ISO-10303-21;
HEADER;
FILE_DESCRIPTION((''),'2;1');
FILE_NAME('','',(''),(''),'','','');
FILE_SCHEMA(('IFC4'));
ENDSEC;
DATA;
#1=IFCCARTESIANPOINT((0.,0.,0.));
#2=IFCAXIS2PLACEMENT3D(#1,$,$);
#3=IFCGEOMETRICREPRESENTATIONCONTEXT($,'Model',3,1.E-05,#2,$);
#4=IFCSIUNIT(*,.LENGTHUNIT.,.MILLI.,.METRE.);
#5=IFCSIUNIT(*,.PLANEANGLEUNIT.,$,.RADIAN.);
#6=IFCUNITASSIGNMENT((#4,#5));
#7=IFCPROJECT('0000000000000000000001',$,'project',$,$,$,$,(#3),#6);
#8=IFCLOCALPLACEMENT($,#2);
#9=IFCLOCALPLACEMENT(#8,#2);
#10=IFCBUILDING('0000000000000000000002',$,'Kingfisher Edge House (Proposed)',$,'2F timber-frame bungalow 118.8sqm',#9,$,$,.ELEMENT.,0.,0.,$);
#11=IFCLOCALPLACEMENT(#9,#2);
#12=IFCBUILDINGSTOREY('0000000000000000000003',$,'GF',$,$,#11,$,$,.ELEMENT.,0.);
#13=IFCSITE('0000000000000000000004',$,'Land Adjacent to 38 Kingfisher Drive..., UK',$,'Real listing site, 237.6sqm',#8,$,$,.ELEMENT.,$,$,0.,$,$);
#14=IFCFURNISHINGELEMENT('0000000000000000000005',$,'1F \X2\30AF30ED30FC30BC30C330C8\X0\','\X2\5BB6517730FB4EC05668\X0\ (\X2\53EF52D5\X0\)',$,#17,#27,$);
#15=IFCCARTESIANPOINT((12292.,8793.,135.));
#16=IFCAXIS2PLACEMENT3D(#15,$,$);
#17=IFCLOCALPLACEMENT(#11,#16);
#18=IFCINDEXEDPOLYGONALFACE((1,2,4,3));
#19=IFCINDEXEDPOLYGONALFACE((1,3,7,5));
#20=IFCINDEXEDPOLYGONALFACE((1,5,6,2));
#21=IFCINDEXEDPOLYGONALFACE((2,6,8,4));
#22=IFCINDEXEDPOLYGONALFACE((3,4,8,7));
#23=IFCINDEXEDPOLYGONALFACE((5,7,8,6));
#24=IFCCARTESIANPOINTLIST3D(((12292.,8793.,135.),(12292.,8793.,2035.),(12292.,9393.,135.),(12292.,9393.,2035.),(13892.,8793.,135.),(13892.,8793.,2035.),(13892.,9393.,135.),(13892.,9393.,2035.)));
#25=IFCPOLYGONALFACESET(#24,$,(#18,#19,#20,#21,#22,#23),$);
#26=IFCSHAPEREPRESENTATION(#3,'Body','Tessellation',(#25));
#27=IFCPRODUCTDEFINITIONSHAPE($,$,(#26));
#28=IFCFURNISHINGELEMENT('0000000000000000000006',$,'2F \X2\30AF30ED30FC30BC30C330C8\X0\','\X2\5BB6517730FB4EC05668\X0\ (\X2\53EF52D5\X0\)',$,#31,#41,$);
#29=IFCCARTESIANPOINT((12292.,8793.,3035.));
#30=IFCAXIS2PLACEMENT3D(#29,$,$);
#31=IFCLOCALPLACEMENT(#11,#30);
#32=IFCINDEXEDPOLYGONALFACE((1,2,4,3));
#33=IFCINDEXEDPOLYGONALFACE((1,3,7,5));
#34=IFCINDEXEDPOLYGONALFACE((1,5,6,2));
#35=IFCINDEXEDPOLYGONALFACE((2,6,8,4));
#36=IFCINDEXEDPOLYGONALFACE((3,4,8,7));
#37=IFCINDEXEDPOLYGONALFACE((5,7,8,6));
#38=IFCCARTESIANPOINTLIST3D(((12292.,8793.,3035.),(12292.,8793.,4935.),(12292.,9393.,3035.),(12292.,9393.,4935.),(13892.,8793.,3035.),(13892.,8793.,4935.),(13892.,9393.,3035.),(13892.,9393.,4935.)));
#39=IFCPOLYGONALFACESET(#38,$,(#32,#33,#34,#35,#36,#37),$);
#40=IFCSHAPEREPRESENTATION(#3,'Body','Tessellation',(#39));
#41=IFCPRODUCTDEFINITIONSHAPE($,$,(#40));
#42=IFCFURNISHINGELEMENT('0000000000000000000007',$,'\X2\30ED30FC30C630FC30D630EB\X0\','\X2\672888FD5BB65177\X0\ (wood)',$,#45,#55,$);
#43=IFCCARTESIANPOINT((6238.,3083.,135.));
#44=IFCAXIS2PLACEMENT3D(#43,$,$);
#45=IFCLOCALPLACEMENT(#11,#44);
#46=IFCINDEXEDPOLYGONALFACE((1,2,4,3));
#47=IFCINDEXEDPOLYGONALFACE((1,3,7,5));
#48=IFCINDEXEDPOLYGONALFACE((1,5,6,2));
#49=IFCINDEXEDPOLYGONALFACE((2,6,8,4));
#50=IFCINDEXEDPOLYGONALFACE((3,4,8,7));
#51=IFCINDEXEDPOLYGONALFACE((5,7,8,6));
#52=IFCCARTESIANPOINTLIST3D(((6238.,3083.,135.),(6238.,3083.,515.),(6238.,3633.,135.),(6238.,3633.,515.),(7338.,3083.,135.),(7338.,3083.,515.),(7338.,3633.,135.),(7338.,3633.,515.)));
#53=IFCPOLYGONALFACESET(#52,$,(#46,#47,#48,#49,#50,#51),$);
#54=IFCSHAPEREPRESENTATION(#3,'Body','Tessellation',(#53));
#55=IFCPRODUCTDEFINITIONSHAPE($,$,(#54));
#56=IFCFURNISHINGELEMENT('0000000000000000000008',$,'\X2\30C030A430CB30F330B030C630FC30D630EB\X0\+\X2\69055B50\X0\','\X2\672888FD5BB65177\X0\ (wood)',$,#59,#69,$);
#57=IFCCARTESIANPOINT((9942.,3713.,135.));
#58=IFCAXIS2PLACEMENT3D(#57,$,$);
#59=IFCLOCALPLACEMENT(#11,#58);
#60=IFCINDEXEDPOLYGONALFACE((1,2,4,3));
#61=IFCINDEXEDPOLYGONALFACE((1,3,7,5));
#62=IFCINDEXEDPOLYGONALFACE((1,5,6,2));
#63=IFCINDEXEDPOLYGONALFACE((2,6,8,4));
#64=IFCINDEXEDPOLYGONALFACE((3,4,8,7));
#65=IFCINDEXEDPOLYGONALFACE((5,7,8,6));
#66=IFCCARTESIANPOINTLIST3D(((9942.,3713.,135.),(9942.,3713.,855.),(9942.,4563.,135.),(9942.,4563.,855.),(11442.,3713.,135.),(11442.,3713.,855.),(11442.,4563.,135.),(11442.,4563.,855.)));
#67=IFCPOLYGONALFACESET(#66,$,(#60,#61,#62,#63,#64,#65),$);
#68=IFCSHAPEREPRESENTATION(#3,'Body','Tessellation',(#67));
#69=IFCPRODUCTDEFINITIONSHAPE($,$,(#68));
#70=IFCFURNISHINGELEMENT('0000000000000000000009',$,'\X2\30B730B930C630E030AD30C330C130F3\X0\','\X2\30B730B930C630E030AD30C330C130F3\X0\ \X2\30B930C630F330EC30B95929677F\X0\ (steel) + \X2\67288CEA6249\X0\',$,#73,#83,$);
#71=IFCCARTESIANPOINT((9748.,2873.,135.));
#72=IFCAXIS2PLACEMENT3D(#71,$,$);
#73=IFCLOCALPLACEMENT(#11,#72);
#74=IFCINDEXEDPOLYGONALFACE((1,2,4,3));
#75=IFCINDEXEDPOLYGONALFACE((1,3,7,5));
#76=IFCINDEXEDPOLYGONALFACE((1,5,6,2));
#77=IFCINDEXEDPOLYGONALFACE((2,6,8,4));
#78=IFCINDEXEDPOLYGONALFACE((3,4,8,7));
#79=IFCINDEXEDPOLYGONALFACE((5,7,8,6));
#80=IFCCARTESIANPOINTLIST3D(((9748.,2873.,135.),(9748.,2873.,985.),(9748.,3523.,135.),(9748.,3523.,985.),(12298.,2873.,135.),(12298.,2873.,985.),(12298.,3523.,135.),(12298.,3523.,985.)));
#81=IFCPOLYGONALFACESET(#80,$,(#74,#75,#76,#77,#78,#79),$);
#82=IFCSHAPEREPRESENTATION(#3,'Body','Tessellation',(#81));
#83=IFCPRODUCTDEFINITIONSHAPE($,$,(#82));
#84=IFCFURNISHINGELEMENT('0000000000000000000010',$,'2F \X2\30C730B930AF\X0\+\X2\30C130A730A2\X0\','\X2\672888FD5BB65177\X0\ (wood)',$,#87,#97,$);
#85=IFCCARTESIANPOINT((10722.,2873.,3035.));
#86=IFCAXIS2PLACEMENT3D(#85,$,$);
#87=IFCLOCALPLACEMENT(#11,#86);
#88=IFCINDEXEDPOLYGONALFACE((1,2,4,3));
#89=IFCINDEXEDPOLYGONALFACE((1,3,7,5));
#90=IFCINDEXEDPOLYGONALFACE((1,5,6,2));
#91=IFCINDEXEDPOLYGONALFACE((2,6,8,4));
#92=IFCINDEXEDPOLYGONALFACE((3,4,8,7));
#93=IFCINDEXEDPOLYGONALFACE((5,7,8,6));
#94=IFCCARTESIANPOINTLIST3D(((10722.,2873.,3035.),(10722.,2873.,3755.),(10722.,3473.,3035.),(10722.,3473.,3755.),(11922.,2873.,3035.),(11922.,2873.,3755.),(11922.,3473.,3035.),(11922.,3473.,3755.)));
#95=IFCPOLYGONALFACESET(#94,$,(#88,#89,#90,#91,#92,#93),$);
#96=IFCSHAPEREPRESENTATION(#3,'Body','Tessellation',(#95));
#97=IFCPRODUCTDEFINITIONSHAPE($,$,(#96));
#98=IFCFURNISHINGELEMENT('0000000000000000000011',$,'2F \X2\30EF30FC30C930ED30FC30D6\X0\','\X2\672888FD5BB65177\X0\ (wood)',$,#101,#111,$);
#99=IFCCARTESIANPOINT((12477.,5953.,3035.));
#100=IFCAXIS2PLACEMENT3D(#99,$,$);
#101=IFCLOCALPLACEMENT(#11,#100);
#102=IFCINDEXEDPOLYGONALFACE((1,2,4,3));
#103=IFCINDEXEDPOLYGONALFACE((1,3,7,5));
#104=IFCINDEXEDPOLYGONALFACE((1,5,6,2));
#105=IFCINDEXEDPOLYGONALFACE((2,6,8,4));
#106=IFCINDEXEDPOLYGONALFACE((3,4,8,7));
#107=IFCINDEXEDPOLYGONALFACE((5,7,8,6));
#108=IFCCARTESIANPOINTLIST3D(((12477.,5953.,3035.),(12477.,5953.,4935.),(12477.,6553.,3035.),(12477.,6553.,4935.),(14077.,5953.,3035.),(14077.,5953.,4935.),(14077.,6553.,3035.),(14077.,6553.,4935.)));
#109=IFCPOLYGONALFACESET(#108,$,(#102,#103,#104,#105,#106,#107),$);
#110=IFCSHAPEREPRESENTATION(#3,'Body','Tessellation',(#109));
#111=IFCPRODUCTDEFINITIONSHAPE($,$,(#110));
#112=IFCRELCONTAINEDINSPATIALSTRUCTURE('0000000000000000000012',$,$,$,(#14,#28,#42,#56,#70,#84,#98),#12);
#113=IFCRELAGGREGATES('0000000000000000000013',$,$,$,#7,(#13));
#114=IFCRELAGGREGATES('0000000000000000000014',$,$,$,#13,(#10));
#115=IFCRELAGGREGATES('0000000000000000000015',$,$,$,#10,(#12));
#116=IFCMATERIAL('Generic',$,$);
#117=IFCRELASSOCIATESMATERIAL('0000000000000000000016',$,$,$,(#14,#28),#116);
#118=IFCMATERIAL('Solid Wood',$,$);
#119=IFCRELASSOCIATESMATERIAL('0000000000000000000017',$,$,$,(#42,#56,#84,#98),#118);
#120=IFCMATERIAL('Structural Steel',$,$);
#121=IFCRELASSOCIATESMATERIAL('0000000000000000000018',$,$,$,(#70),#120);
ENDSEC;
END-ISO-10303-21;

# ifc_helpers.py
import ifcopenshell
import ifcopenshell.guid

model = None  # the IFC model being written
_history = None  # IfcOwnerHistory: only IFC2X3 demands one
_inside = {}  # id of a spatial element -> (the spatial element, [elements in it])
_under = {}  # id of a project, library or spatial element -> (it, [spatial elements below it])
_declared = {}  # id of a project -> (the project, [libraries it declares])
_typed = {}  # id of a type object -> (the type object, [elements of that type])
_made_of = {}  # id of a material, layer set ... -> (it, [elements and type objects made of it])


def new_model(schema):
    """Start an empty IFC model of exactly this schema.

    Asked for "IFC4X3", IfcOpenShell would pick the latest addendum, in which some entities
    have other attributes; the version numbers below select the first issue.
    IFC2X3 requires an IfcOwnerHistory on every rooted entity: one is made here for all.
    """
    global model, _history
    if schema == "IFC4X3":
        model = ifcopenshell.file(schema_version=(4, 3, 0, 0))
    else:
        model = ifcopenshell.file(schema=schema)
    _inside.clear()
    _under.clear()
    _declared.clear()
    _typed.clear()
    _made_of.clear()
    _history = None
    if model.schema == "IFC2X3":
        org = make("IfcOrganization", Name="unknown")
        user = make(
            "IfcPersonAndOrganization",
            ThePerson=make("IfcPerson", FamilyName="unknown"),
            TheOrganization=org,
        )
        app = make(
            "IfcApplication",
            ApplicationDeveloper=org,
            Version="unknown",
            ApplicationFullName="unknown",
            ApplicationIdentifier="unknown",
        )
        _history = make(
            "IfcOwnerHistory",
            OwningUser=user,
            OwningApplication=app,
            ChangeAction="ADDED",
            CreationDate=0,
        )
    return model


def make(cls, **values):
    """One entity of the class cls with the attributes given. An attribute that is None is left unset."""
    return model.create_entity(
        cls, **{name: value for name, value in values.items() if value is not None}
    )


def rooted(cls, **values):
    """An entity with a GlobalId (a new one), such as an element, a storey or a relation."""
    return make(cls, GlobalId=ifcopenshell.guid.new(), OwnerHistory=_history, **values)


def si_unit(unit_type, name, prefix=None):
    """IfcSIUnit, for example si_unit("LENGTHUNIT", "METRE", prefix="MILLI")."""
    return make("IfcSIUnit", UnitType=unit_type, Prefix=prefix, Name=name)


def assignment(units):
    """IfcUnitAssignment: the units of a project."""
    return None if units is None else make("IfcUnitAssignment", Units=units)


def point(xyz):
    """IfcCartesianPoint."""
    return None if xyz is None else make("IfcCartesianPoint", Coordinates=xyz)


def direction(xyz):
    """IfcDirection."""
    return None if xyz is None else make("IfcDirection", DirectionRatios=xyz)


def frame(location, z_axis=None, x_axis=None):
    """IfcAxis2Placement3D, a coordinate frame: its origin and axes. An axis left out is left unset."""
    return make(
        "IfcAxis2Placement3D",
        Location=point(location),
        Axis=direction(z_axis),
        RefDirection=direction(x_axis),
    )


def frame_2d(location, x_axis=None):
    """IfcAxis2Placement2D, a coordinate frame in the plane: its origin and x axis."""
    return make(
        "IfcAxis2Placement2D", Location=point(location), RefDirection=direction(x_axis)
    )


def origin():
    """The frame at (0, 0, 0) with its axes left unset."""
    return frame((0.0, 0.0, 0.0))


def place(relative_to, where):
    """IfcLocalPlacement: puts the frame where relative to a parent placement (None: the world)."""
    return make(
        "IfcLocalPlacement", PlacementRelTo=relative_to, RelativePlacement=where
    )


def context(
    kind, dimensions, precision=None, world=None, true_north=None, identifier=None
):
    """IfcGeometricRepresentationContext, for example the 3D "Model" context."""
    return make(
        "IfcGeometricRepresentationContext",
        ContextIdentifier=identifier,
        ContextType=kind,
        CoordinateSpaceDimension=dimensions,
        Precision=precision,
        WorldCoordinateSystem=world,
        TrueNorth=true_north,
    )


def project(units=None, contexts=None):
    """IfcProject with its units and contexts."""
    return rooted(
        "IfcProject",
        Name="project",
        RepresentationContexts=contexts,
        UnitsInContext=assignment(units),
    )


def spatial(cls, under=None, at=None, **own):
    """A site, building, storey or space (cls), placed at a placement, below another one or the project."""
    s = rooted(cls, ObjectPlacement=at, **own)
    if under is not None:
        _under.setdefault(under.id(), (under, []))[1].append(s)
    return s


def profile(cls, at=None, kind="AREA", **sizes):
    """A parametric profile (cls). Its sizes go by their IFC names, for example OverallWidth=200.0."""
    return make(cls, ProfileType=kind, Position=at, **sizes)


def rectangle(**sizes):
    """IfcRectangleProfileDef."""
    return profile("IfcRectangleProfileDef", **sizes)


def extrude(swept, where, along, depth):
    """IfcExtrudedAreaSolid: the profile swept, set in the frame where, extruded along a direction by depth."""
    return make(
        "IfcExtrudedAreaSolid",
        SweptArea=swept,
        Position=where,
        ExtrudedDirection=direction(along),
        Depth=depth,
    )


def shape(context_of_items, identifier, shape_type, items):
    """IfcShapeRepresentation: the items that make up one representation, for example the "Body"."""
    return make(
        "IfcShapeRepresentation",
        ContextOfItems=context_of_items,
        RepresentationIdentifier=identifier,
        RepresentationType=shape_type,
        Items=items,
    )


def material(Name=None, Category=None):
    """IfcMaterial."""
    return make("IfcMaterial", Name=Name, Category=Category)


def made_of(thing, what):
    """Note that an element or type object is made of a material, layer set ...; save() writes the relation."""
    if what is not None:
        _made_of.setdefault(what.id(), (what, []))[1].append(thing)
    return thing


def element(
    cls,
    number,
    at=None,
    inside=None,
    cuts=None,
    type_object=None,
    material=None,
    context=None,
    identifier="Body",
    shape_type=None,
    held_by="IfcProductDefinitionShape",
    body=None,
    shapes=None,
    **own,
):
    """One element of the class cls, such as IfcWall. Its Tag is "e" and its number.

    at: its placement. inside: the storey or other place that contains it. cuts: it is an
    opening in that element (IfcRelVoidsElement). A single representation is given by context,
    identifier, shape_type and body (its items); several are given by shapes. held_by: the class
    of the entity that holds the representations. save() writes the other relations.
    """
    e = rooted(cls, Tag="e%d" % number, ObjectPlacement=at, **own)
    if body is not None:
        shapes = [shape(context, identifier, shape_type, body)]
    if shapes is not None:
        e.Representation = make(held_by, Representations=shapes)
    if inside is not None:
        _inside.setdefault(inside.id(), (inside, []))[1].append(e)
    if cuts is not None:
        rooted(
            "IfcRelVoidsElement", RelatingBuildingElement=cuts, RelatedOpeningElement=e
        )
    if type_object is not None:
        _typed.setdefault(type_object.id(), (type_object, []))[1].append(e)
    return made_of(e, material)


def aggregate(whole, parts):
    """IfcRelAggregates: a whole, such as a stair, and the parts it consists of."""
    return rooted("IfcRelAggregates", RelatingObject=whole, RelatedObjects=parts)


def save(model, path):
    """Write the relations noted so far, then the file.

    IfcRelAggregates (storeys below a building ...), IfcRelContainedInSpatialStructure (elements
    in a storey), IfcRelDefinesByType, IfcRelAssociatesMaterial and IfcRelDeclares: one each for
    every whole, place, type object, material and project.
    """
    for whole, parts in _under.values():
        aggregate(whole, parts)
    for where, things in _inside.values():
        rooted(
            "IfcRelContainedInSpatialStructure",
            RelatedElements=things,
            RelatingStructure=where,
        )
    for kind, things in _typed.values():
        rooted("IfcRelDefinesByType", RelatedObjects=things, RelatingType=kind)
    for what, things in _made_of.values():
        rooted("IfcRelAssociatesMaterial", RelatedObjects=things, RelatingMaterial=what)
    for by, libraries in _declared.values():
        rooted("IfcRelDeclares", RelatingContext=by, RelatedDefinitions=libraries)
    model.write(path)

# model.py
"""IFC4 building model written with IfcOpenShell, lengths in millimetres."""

from ifc_helpers import new_model, si_unit, frame, frame_2d, origin, place, context, project, spatial, rectangle, extrude, material, element, save


model = new_model("IFC4")

# Units and contexts
model_context = context("Model", 3, precision=1e-05, world=origin())
ifc_project = project(units=[si_unit("LENGTHUNIT", "METRE", prefix="MILLI"), si_unit("PLANEANGLEUNIT", "RADIAN")], contexts=[model_context])

# Site, building, storey
site_placement = place(None, origin())
site = spatial("IfcSite", under=ifc_project, at=site_placement, Name="Land Adjacent to 38 Kingfisher Drive..., UK", ObjectType="Real listing site, 237.6sqm", CompositionType="ELEMENT", RefElevation=0.0)
building_placement = place(site_placement, origin())
building = spatial("IfcBuilding", under=site, at=building_placement, Name="Kingfisher Edge House (Proposed)", ObjectType="2F timber-frame bungalow 118.8sqm", CompositionType="ELEMENT", ElevationOfRefHeight=0.0, ElevationOfTerrain=0.0)
storey_placement = place(building_placement, origin())
storey = spatial("IfcBuildingStorey", under=building, at=storey_placement, Name="GF", CompositionType="ELEMENT", Elevation=0.0)

# Shared definitions
ifc_material_1 = material(Name="Solid Wood")

# Shared definitions
ifc_material_2 = material(Name="Generic")

# Furnishing elements
furnishing_1_placement = place(storey_placement, frame((12292.0, 8793.0, 135.0)))
element("IfcFurnishingElement", 1, at=furnishing_1_placement, inside=storey, material=ifc_material_2, Name="1F クローゼット", Description="家具・什器 (可動)", context=model_context, shape_type="SweptSolid", body=[
    extrude(rectangle(XDim=1600.0, YDim=600.0, at=frame_2d((800.0, 300.0))), frame((12292.0, 8793.0, 135.0)), (0.0, 0.0, 1.0), 1900.0),
])
furnishing_2_placement = place(storey_placement, frame((12292.0, 8793.0, 3035.0)))
element("IfcFurnishingElement", 2, at=furnishing_2_placement, inside=storey, material=ifc_material_2, Name="2F クローゼット", Description="家具・什器 (可動)", context=model_context, shape_type="SweptSolid", body=[
    extrude(rectangle(XDim=1600.0, YDim=600.0, at=frame_2d((800.0, 300.0))), frame((12292.0, 8793.0, 3035.0)), (0.0, 0.0, 1.0), 1900.0),
])
furnishing_3_placement = place(storey_placement, frame((6238.0, 3083.0, 135.0)))
element("IfcFurnishingElement", 3, at=furnishing_3_placement, inside=storey, material=ifc_material_1, Name="ローテーブル", Description="木製家具 (wood)", context=model_context, shape_type="SweptSolid", body=[
    extrude(rectangle(XDim=1100.0, YDim=550.0, at=frame_2d((550.0, 275.0))), frame((6238.0, 3083.0, 135.0)), (0.0, 0.0, 1.0), 380.0),
])
furnishing_4_placement = place(storey_placement, frame((9942.0, 3713.0, 135.0)))
element("IfcFurnishingElement", 4, at=furnishing_4_placement, inside=storey, material=ifc_material_1, Name="ダイニングテーブル+椅子", Description="木製家具 (wood)", context=model_context, shape_type="SweptSolid", body=[
    extrude(rectangle(XDim=1500.0, YDim=850.0, at=frame_2d((750.0, 425.0))), frame((9942.0, 3713.0, 135.0)), (0.0, 0.0, 1.0), 720.0),
])
ifc_material_3 = material(Name="Structural Steel")
furnishing_5_placement = place(storey_placement, frame((9748.0, 2873.0, 135.0)))
element("IfcFurnishingElement", 5, at=furnishing_5_placement, inside=storey, material=ifc_material_3, Name="システムキッチン", Description="システムキッチン ステンレス天板 (steel) + 木質扉", context=model_context, shape_type="SweptSolid", body=[
    extrude(rectangle(XDim=2550.0, YDim=650.0, at=frame_2d((1275.0, 325.0))), frame((9748.0, 2873.0, 135.0)), (0.0, 0.0, 1.0), 850.0),
])
furnishing_6_placement = place(storey_placement, frame((10722.0, 2873.0, 3035.0)))
element("IfcFurnishingElement", 6, at=furnishing_6_placement, inside=storey, material=ifc_material_1, Name="2F デスク+チェア", Description="木製家具 (wood)", context=model_context, shape_type="SweptSolid", body=[
    extrude(rectangle(XDim=1200.0, YDim=600.0, at=frame_2d((600.0, 300.0))), frame((10722.0, 2873.0, 3035.0)), (0.0, 0.0, 1.0), 720.0),
])
furnishing_7_placement = place(storey_placement, frame((12477.0, 5953.0, 3035.0)))
element("IfcFurnishingElement", 7, at=furnishing_7_placement, inside=storey, material=ifc_material_1, Name="2F ワードローブ", Description="木製家具 (wood)", context=model_context, shape_type="SweptSolid", body=[
    extrude(rectangle(XDim=1600.0, YDim=600.0, at=frame_2d((800.0, 300.0))), frame((12477.0, 5953.0, 3035.0)), (0.0, 0.0, 1.0), 1900.0),
])

save(model, "model.ifc")
